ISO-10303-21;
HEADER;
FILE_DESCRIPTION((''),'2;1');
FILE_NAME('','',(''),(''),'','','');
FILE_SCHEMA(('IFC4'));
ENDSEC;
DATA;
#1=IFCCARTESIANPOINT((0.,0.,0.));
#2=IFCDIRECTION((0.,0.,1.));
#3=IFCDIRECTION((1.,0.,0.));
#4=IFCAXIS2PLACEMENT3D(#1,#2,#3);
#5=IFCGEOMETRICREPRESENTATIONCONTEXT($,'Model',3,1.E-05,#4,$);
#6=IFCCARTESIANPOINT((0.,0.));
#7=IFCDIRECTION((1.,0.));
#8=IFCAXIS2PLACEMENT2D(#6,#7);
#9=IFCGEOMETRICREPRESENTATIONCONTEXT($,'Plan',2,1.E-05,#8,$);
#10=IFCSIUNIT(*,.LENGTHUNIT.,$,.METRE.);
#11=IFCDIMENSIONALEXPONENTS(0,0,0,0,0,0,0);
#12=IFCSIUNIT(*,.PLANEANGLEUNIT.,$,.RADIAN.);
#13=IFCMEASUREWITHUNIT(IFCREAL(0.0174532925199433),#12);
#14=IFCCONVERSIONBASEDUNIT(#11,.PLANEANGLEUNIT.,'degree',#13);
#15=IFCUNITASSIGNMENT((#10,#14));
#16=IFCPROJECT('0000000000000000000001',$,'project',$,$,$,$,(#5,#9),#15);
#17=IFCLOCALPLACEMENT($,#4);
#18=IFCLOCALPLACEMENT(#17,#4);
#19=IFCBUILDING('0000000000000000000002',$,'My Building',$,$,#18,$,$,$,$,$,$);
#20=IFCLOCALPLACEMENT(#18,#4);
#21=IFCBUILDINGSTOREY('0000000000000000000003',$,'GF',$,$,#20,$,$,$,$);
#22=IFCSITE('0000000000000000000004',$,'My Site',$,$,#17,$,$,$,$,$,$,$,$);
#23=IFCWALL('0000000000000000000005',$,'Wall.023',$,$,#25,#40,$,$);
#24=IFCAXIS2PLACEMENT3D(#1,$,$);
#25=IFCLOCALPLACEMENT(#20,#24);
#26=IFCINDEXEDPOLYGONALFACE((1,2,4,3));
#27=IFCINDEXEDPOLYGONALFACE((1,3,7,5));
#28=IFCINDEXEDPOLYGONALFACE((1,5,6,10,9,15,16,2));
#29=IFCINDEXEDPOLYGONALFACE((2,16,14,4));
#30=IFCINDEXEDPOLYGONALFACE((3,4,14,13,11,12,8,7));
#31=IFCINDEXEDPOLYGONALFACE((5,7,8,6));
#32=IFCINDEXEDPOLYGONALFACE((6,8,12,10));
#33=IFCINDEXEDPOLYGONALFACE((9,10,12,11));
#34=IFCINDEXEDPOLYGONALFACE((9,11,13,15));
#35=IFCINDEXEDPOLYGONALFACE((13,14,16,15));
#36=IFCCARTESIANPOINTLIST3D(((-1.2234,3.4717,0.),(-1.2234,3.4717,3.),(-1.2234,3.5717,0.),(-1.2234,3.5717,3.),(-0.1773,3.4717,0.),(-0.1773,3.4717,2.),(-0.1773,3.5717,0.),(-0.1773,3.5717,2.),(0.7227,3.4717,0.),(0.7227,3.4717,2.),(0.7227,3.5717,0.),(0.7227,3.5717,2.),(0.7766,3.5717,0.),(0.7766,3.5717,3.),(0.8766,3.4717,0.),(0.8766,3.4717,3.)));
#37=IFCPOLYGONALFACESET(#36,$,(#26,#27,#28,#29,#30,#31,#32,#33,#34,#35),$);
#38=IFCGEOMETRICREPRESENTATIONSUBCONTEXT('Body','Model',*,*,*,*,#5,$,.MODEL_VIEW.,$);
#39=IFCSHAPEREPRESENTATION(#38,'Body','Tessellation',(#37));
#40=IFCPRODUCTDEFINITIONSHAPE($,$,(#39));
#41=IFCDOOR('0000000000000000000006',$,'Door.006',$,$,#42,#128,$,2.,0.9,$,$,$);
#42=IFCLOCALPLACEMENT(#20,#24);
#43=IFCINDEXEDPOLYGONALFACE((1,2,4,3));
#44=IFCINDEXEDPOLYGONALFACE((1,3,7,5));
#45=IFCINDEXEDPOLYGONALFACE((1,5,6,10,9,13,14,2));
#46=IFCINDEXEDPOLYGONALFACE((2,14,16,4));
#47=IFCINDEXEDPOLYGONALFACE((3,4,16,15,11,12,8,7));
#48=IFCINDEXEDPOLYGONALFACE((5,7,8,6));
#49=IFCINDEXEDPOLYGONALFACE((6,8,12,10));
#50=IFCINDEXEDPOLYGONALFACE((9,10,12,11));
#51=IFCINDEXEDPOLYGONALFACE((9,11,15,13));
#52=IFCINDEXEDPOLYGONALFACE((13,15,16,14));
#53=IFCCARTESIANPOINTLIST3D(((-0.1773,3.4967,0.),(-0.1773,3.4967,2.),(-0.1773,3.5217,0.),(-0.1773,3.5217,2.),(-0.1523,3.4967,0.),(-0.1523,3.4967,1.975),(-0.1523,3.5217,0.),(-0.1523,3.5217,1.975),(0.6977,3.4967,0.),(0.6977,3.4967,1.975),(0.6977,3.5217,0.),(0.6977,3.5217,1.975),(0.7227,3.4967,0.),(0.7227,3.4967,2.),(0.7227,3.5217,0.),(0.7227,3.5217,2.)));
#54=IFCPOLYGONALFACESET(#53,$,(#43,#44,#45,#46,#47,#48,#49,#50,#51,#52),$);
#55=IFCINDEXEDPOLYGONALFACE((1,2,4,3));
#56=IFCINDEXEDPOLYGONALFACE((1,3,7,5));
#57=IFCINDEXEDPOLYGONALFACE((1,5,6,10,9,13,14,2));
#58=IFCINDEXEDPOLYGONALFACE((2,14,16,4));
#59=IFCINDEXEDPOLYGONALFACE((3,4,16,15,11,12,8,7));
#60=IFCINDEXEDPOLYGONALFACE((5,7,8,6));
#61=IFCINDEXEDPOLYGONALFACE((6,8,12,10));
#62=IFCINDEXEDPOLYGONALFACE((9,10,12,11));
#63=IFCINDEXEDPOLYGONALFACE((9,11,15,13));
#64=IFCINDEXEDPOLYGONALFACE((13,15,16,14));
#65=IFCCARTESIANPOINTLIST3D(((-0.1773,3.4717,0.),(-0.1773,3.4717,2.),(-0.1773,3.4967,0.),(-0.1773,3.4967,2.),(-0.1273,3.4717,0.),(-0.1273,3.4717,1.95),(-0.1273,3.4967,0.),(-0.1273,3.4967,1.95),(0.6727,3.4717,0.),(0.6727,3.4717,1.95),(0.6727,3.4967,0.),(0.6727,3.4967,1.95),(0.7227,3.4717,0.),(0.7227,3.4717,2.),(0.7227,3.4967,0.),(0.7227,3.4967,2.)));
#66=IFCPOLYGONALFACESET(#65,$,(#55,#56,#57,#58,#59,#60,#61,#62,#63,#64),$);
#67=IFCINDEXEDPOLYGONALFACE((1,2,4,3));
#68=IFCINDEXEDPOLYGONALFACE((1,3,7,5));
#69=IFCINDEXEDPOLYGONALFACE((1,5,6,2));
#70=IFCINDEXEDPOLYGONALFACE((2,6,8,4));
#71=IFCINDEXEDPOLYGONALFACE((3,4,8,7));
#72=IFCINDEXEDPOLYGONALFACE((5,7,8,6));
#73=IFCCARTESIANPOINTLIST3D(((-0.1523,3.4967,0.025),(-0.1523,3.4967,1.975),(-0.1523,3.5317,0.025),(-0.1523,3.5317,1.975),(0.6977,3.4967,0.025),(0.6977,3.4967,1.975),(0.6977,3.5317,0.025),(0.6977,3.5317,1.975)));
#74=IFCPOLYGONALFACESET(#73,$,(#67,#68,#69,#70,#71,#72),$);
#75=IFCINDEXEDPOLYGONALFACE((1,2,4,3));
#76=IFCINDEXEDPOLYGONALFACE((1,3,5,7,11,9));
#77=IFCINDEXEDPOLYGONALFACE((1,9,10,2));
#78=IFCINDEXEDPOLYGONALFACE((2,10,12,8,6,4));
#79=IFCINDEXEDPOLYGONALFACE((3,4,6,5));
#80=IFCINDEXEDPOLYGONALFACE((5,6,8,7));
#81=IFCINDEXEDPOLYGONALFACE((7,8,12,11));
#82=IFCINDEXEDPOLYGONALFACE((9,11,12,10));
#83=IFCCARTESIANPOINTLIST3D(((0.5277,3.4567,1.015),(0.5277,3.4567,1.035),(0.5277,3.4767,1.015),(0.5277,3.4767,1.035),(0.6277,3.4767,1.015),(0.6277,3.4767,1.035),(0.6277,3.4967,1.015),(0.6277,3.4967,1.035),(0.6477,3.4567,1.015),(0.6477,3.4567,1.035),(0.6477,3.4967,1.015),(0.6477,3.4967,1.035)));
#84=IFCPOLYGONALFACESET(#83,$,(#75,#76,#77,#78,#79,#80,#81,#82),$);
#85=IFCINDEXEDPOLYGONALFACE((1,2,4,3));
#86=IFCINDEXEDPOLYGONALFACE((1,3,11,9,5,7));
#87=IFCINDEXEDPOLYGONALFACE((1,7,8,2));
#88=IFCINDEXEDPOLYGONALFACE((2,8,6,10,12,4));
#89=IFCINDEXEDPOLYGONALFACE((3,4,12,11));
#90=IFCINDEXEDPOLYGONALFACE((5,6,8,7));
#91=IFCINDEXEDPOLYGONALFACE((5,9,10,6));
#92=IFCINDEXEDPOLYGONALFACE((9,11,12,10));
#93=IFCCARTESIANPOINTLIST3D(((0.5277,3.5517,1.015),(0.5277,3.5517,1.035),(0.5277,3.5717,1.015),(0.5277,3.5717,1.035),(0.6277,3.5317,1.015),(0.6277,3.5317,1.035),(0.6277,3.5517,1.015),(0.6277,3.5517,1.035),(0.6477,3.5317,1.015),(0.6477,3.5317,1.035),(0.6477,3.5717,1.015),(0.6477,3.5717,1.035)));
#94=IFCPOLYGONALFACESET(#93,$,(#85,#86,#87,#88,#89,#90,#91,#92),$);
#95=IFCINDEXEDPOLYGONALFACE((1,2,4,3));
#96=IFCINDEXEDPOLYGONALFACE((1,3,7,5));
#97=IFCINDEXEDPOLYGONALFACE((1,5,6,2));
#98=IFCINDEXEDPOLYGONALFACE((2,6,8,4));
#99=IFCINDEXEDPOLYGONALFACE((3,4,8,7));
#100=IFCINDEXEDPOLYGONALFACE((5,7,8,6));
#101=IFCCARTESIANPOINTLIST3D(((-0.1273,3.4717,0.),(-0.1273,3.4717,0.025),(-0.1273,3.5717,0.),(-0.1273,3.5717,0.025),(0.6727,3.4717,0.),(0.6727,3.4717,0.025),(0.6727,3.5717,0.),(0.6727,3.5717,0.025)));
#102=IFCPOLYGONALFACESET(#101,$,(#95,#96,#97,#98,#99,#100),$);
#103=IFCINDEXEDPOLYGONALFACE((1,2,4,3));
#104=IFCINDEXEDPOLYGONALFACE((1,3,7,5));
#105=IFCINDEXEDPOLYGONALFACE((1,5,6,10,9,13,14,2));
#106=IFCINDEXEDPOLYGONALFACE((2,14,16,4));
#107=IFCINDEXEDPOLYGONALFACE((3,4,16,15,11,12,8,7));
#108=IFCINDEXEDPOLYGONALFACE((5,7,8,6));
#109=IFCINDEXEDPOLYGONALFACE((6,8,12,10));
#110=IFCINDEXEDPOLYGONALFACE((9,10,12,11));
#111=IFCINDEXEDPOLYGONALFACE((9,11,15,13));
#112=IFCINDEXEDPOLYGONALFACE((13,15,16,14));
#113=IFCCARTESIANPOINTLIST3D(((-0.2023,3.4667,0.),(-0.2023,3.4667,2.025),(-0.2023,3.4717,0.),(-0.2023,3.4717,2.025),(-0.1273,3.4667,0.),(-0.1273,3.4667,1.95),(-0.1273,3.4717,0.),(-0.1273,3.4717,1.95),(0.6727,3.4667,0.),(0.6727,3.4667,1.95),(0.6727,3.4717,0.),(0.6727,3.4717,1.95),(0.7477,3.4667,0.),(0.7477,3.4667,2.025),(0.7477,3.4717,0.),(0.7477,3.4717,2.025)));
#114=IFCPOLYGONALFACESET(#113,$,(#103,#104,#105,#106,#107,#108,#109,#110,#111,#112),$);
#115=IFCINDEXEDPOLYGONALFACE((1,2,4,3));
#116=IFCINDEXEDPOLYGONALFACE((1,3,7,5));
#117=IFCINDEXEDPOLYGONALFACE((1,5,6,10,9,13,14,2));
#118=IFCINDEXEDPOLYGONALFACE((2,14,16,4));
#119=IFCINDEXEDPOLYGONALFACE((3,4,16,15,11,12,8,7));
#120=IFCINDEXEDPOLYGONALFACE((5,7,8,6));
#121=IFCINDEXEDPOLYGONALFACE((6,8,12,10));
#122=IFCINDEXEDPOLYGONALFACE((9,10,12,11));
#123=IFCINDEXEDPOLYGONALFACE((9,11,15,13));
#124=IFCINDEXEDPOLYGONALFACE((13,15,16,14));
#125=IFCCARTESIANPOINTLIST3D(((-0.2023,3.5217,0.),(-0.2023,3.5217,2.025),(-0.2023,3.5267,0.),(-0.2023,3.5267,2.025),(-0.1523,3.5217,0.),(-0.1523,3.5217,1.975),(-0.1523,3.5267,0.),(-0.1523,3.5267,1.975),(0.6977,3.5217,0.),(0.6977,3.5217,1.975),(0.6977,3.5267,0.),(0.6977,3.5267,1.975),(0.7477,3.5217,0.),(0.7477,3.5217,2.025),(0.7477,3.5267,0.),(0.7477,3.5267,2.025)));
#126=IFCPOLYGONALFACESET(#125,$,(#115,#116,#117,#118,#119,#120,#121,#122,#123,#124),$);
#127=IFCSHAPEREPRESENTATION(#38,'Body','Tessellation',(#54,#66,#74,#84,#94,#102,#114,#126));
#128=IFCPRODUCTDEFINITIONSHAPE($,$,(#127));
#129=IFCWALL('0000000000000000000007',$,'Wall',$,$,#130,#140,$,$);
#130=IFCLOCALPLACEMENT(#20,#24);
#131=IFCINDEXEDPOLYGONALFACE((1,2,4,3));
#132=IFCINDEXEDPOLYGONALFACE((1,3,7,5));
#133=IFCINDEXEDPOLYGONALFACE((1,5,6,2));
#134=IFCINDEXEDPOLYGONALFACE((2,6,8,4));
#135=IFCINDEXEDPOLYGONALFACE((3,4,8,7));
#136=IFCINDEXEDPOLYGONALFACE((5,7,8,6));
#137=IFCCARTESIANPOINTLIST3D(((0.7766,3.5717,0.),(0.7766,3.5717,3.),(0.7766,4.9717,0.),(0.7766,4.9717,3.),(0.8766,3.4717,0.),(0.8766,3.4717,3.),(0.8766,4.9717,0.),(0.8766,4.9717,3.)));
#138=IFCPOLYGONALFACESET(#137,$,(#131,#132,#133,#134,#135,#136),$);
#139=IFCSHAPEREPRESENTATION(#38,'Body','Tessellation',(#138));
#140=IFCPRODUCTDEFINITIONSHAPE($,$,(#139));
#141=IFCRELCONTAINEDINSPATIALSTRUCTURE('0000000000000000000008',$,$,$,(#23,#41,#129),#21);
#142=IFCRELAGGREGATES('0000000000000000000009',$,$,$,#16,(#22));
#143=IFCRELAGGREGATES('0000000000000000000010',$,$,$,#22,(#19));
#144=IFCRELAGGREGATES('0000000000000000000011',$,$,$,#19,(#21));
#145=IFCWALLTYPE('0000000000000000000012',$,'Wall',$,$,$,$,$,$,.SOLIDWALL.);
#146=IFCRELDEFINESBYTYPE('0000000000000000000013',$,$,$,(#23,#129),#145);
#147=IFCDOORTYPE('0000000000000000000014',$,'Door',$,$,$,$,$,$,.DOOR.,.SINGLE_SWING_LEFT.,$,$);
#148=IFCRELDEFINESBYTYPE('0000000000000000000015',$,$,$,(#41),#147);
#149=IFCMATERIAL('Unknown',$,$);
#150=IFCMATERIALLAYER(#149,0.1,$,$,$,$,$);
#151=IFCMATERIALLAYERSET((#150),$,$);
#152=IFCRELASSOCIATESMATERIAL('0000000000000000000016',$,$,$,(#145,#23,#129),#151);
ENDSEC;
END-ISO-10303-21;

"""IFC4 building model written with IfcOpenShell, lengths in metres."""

from ifc_helpers import new_model, entity, si_unit, converted_unit, frame, origin_with_axes, origin_2d_with_axis, place, context, subcontext, project, spatial, line, indexed_curve, outline, extrude, shape, source, transform, mapped, material, layer, layer_set, layer_usage, type_object, type_shapes, element, fill, save


model = new_model("IFC4")

# Units and contexts
model_context = context("Model", 3, precision=1e-05, world=origin_with_axes())
plan_context = context("Plan", 2, precision=1e-05, world=origin_2d_with_axis())
body_context_1 = subcontext(model_context, "Body", "Model", "MODEL_VIEW")
body_context_2 = subcontext(plan_context, "Body", "Plan", "PLAN_VIEW")
ifc_project = project(units=[si_unit("LENGTHUNIT", "METRE"), converted_unit("PLANEANGLEUNIT", "degree", entity("IfcReal", 0.0174532925199433), si_unit("PLANEANGLEUNIT", "RADIAN"), dimensions=[0, 0, 0, 0, 0, 0, 0])], contexts=[model_context, plan_context])

# Site, building, storey
site_placement = place(None, origin_with_axes())
site = spatial("IfcSite", under=ifc_project, at=site_placement, Name="My Site")
building_placement = place(site_placement, origin_with_axes())
building = spatial("IfcBuilding", under=site, at=building_placement, Name="My Building")
storey_placement = place(building_placement, origin_with_axes())
storey = spatial("IfcBuildingStorey", under=building, at=storey_placement, Name="GF")

# Shared definitions
ifc_material_1 = material(Name="Unknown")

# Shared definitions
ifc_layer_1 = layer(ifc_material_1, 0.1)
ifc_layer_set_1 = layer_set([ifc_layer_1])
wall_type = type_object("IfcWallType", Name="Wall", PredefinedType="SOLIDWALL", material=ifc_layer_set_1)

# Shared definitions
shared_shape_1 = source(origin_with_axes(), body_context_1, "Body", "SweptSolid", [
    extrude(outline(indexed_curve([(0.0, 0.0), (0.9, 0.0), (0.9, 2.0), (0.0, 2.0)], segments=[line(1, 2, 3, 4, 1)])), frame((0.0, -0.6, 0.0), z_axis=(0.0, -1.0, 0.0), x_axis=(1.0, 0.0, 0.0)), (0.0, 0.0, -1.0), 1.2),
])
door_type = type_object("IfcDoorType", Name="Door", OperationType="SINGLE_SWING_LEFT", PredefinedType="DOOR")
shared_shape_2 = source(origin_with_axes(), body_context_1, "Body", "SweptSolid", [
    extrude(outline(indexed_curve([(0.0, 0.0), (0.0, 2.0), (0.9, 2.0), (0.9, 0.0), (0.875, 0.0), (0.875, 1.975), (0.025, 1.975), (0.025, 0.0)], segments=[line(1, 2, 3, 4, 5, 6, 7, 8, 1)])), frame((0.0, 0.025, 0.0), z_axis=(0.0, -1.0, 0.0), x_axis=(1.0, 0.0, 0.0)), (0.0, 0.0, -1.0), 0.025),
    extrude(outline(indexed_curve([(0.0, 0.0), (0.0, 2.0), (0.9, 2.0), (0.9, 0.0), (0.85, 0.0), (0.85, 1.95), (0.05, 1.95), (0.05, 0.0)], segments=[line(1, 2, 3, 4, 5, 6, 7, 8, 1)])), frame((0.0, 0.0, 0.0), z_axis=(0.0, -1.0, 0.0), x_axis=(1.0, 0.0, 0.0)), (0.0, 0.0, -1.0), 0.025),
    extrude(outline(indexed_curve([(0.0, 0.0), (0.85, 0.0), (0.85, 0.035), (0.0, 0.035)], segments=[line(1, 2, 3, 4, 1)])), frame((0.025, 0.025, 0.025), z_axis=(0.0, 0.0, 1.0), x_axis=(1.0, 0.0, 0.0)), (0.0, 0.0, 1.0), 1.95),
    extrude(outline(indexed_curve([(0.0, 0.0), (0.0, -0.04), (-0.12, -0.04), (-0.12, -0.02), (-0.02, -0.02), (-0.02, 0.0)], segments=[line(1, 2, 3, 4, 5, 6, 1)])), frame((0.825, 0.025, 1.015), z_axis=(0.0, 0.0, 1.0), x_axis=(1.0, 0.0, 0.0)), (0.0, 0.0, 1.0), 0.02),
    extrude(outline(indexed_curve([(0.0, 0.0), (0.0, 0.04), (-0.12, 0.04), (-0.12, 0.02), (-0.02, 0.02), (-0.02, 0.0)], segments=[line(1, 2, 3, 4, 5, 6, 1)])), frame((0.825, 0.06, 1.015), z_axis=(0.0, 0.0, 1.0), x_axis=(1.0, 0.0, 0.0)), (0.0, 0.0, 1.0), 0.02),
    extrude(outline(indexed_curve([(0.0, 0.0), (0.8, 0.0), (0.8, 0.1), (0.0, 0.1)], segments=[line(1, 2, 3, 4, 1)])), frame((0.05, 0.0, 0.0), z_axis=(0.0, 0.0, 1.0), x_axis=(1.0, 0.0, 0.0)), (0.0, 0.0, 1.0), 0.025),
    extrude(outline(indexed_curve([(0.0, 0.0), (0.0, 2.025), (0.95, 2.025), (0.95, 0.0), (0.875, 0.0), (0.875, 1.95), (0.075, 1.95), (0.075, 0.0)], segments=[line(1, 2, 3, 4, 5, 6, 7, 8, 1)])), frame((-0.025, -0.005, 0.0), z_axis=(0.0, -1.0, 0.0), x_axis=(1.0, 0.0, 0.0)), (0.0, 0.0, -1.0), 0.005),
    extrude(outline(indexed_curve([(0.0, 0.0), (0.0, 2.025), (0.95, 2.025), (0.95, 0.0), (0.9, 0.0), (0.9, 1.975), (0.05, 1.975), (0.05, 0.0)], segments=[line(1, 2, 3, 4, 5, 6, 7, 8, 1)])), frame((-0.025, 0.05, 0.0), z_axis=(0.0, -1.0, 0.0), x_axis=(1.0, 0.0, 0.0)), (0.0, 0.0, -1.0), 0.005),
])
shared_shape_3 = source(origin_with_axes(), body_context_2, "Body", "Curve2D", [
    entity("IfcIndexedPolyCurve", entity("IfcCartesianPointList2D", [[0.0, 0.0], [0.0, 0.05], [0.025, 0.05], [0.025, 0.025], [0.05, 0.025], [0.05, 0.0]]), [entity("IfcLineIndex", [1, 2, 3, 4, 5, 6, 1])]),
    entity("IfcIndexedPolyCurve", entity("IfcCartesianPointList2D", [[0.9, 0.0], [0.9, 0.05], [0.875, 0.05], [0.875, 0.025], [0.85, 0.025], [0.85, 0.0]]), [entity("IfcLineIndex", [1, 2, 3, 4, 5, 6, 1])]),
    entity("IfcTrimmedCurve", entity("IfcEllipse", entity("IfcAxis2Placement2D", entity("IfcCartesianPoint", [0.06, 0.05]), entity("IfcDirection", [1.0, 0.0])), 0.815, 0.85), [entity("IfcCartesianPoint", [0.875, 0.05])], [entity("IfcCartesianPoint", [0.06, 0.9])], True, "CARTESIAN"),
    entity("IfcIndexedPolyCurve", entity("IfcCartesianPointList2D", [[0.025, 0.05], [0.06, 0.05], [0.06, 0.9], [0.025, 0.9]]), [entity("IfcLineIndex", [1, 2, 3, 4, 1])]),
])
type_shapes(door_type, [shared_shape_2, shared_shape_3])

# Wall, opening, door
ifc_layer_usage_1 = layer_usage(ifc_layer_set_1, "AXIS2", "POSITIVE", 0.0)
wall_1_placement = place(storey_placement, frame((-1.2234, 3.4717, 0.0), z_axis=(0.0, 0.0, 1.0), x_axis=(1.0, 0.0, 0.0)))
wall_1 = element("IfcWall", 1, at=wall_1_placement, inside=storey, type_object=wall_type, material=ifc_layer_usage_1, Name="Wall.023", context=body_context_1, shape_type="SweptSolid", body=[
    extrude(outline(indexed_curve([(0.0, 0.0), (0.0, 0.1), (2.0, 0.1), (2.1, 0.0)], segments=[line(1, 2, 3, 4, 1)])), origin_with_axes(), (0.0, 0.0, 1.0), 3.0),
])
opening_1_placement = place(wall_1_placement, frame((1.046, 0.0, 0.0), z_axis=(0.0, 0.0, 1.0), x_axis=(1.0, 0.0, 0.0)))
opening_1 = element("IfcOpeningElement", 2, at=opening_1_placement, cuts=wall_1, PredefinedType="OPENING", context=body_context_1, shape_type="MappedRepresentation", body=[
    mapped(shared_shape_1, transform((0.0, 0.0, 0.0), x_axis=(1.0, 0.0, 0.0), y_axis=(0.0, 1.0, 0.0), z_axis=(0.0, 0.0, 1.0), scale=1.0)),
])
door_1_placement = place(opening_1_placement, origin_with_axes())
door_1 = element("IfcDoor", 3, at=door_1_placement, inside=storey, type_object=door_type, Name="Door.006", OverallHeight=2.0, OverallWidth=0.9, shapes=[
    shape(body_context_1, "Body", "MappedRepresentation", [mapped(shared_shape_2, transform((0.0, 0.0, 0.0), x_axis=(1.0, 0.0, 0.0), y_axis=(0.0, 1.0, 0.0), z_axis=(0.0, 0.0, 1.0), scale=1.0))]),
    shape(body_context_2, "Body", "MappedRepresentation", [mapped(shared_shape_3, transform((0.0, 0.0, 0.0), x_axis=(1.0, 0.0, 0.0), y_axis=(0.0, 1.0, 0.0), z_axis=(0.0, 0.0, 1.0), scale=1.0))]),
])
fill(opening_1, door_1)

# Wall
ifc_layer_usage_2 = layer_usage(ifc_layer_set_1, "AXIS2", "POSITIVE", 0.0)
wall_2_placement = place(storey_placement, frame((0.8766, 3.4717, 0.0), z_axis=(0.0, 0.0, 1.0), x_axis=(0.0, 1.0, 0.0)))
element("IfcWall", 4, at=wall_2_placement, inside=storey, type_object=wall_type, material=ifc_layer_usage_2, Name="Wall", context=body_context_1, shape_type="SweptSolid", body=[
    extrude(outline(indexed_curve([(0.0, 0.0), (0.1, 0.1), (1.5, 0.1), (1.5, 0.0)], segments=[line(1, 2, 3, 4, 1)])), origin_with_axes(), (0.0, 0.0, 1.0), 3.0),
])

save(model, "model.ifc")
